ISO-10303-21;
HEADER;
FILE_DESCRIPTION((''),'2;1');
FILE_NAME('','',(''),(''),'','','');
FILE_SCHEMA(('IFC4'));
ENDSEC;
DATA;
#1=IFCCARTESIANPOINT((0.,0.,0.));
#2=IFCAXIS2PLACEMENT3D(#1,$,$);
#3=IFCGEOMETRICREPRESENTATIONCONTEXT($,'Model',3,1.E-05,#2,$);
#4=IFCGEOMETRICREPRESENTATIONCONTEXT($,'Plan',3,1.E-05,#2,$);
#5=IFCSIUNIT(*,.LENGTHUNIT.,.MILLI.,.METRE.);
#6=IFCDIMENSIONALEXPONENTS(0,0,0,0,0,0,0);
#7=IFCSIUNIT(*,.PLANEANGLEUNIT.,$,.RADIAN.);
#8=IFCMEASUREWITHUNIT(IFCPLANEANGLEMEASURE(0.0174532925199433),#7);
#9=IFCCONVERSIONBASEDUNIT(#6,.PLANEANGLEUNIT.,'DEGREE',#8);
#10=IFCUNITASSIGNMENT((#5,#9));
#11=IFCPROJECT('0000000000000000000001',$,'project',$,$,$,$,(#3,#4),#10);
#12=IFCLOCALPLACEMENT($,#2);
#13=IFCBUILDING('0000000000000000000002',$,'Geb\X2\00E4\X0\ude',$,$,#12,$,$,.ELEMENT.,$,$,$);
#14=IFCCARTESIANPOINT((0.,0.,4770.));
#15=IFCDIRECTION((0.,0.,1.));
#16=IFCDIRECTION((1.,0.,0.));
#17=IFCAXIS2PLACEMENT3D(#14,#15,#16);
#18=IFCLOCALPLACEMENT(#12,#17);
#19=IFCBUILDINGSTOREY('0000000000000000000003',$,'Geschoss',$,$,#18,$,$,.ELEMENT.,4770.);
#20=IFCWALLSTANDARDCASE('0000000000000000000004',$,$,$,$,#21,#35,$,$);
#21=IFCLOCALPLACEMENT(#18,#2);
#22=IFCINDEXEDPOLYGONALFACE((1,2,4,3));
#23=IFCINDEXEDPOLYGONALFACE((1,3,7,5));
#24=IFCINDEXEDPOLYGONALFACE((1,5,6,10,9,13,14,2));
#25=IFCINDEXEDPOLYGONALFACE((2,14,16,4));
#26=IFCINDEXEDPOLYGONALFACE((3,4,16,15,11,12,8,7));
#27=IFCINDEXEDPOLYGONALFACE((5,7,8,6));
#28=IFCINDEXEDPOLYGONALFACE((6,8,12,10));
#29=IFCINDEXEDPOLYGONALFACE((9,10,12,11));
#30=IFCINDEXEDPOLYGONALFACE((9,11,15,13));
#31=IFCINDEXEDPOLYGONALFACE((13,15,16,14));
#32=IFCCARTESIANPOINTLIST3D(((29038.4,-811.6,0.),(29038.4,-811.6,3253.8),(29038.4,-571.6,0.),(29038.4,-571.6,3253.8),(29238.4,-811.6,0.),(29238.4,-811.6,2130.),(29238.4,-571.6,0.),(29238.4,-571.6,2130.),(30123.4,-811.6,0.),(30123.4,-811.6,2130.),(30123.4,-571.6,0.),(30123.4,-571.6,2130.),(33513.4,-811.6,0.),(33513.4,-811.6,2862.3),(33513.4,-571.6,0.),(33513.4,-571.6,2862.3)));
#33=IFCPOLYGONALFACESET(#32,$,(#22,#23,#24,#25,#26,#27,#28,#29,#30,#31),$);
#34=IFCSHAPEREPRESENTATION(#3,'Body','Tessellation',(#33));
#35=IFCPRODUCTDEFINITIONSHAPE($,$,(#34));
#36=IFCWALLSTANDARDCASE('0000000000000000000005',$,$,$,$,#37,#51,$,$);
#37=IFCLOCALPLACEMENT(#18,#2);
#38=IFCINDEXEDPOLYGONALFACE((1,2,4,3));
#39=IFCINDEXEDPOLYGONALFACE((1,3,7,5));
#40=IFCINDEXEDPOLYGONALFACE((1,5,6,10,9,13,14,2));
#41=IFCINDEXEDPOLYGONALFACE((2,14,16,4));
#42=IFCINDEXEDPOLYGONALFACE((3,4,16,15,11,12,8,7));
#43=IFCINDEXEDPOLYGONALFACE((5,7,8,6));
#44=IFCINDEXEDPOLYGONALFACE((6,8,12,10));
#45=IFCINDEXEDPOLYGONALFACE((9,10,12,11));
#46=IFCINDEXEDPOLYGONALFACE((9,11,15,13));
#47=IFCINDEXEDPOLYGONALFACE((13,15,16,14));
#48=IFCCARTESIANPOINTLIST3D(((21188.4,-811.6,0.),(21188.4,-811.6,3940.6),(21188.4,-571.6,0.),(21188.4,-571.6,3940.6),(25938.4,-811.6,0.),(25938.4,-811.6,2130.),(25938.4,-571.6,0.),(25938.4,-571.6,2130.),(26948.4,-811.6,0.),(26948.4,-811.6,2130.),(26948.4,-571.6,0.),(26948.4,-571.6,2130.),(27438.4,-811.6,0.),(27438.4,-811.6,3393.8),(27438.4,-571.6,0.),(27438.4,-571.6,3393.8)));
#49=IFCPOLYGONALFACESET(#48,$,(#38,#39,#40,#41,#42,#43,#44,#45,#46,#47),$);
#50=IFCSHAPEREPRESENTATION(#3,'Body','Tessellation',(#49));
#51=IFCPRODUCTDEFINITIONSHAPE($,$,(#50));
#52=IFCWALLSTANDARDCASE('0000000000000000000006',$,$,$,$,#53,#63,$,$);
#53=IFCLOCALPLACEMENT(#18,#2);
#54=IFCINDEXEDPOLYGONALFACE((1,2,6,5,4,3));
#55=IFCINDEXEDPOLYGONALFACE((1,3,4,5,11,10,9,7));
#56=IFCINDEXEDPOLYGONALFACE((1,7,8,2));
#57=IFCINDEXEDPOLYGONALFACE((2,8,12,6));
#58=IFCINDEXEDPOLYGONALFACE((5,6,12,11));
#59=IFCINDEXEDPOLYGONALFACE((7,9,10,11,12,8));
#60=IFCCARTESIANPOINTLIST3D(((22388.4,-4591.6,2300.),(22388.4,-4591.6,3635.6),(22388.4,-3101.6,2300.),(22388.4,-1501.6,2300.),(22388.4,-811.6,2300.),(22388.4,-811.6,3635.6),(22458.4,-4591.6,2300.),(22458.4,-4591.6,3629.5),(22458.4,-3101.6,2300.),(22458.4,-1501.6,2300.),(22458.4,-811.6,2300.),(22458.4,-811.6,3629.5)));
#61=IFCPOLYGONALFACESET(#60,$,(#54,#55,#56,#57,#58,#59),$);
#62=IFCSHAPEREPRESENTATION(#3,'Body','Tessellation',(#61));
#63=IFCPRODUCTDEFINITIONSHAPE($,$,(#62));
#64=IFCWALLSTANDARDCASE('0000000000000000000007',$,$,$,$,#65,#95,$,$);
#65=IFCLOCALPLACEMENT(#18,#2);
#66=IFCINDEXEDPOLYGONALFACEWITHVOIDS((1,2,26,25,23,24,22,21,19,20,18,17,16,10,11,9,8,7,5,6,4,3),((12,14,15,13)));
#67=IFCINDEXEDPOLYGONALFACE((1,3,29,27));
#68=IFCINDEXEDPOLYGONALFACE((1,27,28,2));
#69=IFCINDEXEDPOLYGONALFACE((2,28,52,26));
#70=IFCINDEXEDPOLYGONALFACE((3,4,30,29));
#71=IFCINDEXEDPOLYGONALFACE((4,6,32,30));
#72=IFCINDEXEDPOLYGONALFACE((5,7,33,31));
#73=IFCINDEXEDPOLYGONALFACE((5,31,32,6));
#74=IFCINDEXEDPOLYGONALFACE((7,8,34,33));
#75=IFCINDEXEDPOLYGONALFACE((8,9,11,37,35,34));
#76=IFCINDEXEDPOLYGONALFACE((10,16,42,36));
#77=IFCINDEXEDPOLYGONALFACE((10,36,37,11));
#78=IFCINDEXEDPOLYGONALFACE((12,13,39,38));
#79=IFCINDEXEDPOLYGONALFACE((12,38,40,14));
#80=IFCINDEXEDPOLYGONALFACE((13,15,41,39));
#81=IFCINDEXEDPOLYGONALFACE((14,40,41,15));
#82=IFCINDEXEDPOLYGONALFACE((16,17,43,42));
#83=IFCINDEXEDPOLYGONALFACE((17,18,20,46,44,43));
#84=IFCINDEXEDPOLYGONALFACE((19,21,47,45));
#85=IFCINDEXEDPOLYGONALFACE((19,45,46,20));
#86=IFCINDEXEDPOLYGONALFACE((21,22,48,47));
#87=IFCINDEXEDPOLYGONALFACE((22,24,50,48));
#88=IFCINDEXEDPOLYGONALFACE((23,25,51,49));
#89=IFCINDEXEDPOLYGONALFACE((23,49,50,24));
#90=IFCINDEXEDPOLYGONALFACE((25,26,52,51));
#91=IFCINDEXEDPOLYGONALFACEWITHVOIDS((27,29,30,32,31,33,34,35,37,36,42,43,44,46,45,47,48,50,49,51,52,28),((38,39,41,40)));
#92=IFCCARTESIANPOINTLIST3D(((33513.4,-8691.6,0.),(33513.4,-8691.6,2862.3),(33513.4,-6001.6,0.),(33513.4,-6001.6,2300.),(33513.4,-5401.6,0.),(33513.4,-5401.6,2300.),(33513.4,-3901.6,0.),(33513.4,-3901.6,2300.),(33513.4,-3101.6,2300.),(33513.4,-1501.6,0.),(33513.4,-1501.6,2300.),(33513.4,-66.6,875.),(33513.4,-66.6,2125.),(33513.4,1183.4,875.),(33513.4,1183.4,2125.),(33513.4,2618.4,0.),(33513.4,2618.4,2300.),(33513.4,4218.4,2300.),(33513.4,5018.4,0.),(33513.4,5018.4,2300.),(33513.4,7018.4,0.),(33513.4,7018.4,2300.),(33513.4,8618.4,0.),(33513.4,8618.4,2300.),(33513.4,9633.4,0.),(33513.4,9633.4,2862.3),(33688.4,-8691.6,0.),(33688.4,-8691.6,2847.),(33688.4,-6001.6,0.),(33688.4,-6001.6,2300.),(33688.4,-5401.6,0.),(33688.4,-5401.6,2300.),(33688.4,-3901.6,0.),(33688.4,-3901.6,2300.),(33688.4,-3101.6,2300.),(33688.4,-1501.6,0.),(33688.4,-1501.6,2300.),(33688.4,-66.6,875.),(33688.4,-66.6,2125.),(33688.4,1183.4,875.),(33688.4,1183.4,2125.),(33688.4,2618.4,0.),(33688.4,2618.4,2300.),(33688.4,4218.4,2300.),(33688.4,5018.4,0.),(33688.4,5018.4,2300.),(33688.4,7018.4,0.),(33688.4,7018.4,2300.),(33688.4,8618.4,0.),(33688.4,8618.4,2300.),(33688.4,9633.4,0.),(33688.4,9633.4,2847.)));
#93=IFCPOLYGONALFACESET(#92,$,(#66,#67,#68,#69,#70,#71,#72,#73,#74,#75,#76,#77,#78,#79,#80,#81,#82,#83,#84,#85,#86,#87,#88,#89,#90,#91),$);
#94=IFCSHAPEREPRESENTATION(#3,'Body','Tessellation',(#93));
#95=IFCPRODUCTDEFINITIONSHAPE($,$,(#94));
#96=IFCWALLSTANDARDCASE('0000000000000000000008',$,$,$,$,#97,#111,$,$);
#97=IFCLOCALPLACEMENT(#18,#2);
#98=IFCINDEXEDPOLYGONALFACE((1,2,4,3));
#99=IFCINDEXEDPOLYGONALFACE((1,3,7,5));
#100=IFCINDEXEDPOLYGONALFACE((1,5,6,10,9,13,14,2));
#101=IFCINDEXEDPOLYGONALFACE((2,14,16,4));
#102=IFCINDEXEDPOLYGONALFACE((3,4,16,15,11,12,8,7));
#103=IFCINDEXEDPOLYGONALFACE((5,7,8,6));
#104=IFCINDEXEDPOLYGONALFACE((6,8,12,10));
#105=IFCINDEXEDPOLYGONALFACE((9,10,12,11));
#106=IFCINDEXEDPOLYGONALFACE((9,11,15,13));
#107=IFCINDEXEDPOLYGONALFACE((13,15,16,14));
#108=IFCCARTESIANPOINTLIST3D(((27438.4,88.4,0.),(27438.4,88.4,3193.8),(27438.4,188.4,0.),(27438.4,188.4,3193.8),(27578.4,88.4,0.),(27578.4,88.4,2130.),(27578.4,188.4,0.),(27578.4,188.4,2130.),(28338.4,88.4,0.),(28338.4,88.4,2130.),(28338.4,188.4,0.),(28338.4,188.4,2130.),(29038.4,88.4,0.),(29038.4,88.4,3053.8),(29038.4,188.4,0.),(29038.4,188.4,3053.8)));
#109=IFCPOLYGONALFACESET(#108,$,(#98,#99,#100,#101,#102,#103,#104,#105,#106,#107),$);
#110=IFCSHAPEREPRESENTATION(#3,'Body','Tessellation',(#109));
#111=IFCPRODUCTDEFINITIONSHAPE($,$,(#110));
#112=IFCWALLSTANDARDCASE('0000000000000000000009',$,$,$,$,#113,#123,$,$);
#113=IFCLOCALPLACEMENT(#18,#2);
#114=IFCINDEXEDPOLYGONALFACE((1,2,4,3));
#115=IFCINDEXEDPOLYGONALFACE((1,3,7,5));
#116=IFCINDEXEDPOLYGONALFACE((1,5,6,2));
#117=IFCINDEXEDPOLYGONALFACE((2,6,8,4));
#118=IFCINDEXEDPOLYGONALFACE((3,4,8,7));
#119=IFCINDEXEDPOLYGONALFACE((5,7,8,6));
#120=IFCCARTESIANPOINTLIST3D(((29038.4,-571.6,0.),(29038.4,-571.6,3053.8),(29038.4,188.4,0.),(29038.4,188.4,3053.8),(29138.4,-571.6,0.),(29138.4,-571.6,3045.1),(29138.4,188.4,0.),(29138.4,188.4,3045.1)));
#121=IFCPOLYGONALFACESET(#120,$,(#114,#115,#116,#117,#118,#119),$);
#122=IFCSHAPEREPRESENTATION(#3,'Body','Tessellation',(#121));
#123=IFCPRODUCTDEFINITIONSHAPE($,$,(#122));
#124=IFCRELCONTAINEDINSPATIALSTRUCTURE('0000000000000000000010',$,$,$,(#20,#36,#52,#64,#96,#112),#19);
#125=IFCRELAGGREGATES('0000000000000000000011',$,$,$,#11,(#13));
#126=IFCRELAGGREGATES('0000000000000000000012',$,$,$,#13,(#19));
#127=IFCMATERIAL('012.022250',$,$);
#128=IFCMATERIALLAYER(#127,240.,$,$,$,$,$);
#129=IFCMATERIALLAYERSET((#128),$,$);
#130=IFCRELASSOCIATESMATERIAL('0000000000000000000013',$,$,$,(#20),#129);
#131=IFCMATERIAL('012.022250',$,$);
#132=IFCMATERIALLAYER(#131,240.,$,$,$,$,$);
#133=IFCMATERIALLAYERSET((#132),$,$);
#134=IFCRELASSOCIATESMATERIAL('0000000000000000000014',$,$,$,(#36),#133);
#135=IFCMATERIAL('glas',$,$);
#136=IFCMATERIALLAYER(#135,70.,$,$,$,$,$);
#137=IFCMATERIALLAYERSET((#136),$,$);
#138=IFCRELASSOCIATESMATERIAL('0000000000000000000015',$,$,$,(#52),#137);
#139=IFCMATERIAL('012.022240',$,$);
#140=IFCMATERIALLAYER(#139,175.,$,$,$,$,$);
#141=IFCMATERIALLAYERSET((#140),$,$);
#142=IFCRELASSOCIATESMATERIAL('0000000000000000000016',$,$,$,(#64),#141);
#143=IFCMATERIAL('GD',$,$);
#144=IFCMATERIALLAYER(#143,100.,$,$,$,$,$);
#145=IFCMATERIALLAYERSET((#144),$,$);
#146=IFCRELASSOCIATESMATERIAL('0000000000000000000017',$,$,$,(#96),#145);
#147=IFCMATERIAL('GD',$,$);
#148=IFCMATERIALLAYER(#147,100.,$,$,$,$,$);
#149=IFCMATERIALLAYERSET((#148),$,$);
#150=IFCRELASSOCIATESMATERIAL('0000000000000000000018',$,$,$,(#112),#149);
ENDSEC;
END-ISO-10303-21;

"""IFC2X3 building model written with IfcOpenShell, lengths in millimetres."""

from ifc_helpers import new_model, entity, si_unit, converted_unit, frame, frame_2d, origin, origin_with_axes, place, context, project, spatial, rectangle, extrude, clip, halfspace, material, layer, layer_set, layer_usage, element, save


model = new_model("IFC2X3")

# Units and contexts
model_context = context("Model", 3, precision=1e-05, world=origin())
plan_context = context("Plan", 3, precision=1e-05, world=origin())
ifc_project = project(units=[si_unit("LENGTHUNIT", "METRE", prefix="MILLI"), converted_unit("PLANEANGLEUNIT", "DEGREE", entity("IfcPlaneAngleMeasure", 0.0174532925199433), si_unit("PLANEANGLEUNIT", "RADIAN"), dimensions=[0, 0, 0, 0, 0, 0, 0])], contexts=[model_context, plan_context])

# Building, storey
building_placement = place(None, origin())
building = spatial("IfcBuilding", under=ifc_project, at=building_placement, Name="Gebäude", CompositionType="ELEMENT")
storey_placement = place(building_placement, frame((0.0, 0.0, 4770.0), z_axis=(0.0, 0.0, 1.0), x_axis=(1.0, 0.0, 0.0)))
storey = spatial("IfcBuildingStorey", under=building, at=storey_placement, Name="Geschoss", CompositionType="ELEMENT", Elevation=4770.0)

# Walls, openings
ifc_material_1 = material(Name="012.022250")
ifc_layer_1 = layer(ifc_material_1, 240.0)
ifc_layer_set_1 = layer_set([ifc_layer_1])
ifc_layer_usage_1 = layer_usage(ifc_layer_set_1, "AXIS2", "POSITIVE", 0.0)
wall_1_placement = place(storey_placement, frame((33513.4, -571.6, 0.0), z_axis=(0.0, 0.0, 1.0), x_axis=(-1.0, 0.0, 0.0)))
wall_1 = element("IfcWallStandardCase", 1, at=wall_1_placement, inside=storey, material=ifc_layer_usage_1, context=model_context, shape_type="Clipping", body=[
    clip(extrude(rectangle(XDim=4475.0, YDim=240.0, at=frame_2d((2237.5, 120.0), x_axis=(1.0, 0.0))), origin_with_axes(), (0.0, 0.0, 1.0), 3253.8), halfspace(frame((0.0, 0.0, 2862.3), z_axis=(0.087156, 0.0, -0.996195), x_axis=(1.0, 0.0, 0.0)), True)),
])
opening_1_placement = place(wall_1_placement, frame((3390.0, 0.0, 0.0), z_axis=(0.0, 1.0, 0.0), x_axis=(0.0, 0.0, 1.0)))
element("IfcOpeningElement", 2, at=opening_1_placement, cuts=wall_1, ObjectType="Opening", context=model_context, shape_type="SweptSolid", body=[
    extrude(rectangle(XDim=2130.0, YDim=885.0, at=frame_2d((1065.0, 442.5), x_axis=(1.0, 0.0))), origin_with_axes(), (0.0, 0.0, 1.0), 240.0),
])
ifc_material_2 = material(Name="012.022250")
ifc_layer_2 = layer(ifc_material_2, 240.0)
ifc_layer_set_2 = layer_set([ifc_layer_2])
ifc_layer_usage_2 = layer_usage(ifc_layer_set_2, "AXIS2", "POSITIVE", 0.0)
wall_2_placement = place(storey_placement, frame((27438.4, -571.6, 0.0), z_axis=(0.0, 0.0, 1.0), x_axis=(-1.0, 0.0, 0.0)))
wall_2 = element("IfcWallStandardCase", 3, at=wall_2_placement, inside=storey, material=ifc_layer_usage_2, context=model_context, shape_type="Clipping", body=[
    clip(extrude(rectangle(XDim=6250.0, YDim=240.0, at=frame_2d((3125.0, 120.0), x_axis=(1.0, 0.0))), origin_with_axes(), (0.0, 0.0, 1.0), 3940.6), halfspace(frame((0.0, 0.0, 3393.8), z_axis=(0.087156, 0.0, -0.996195), x_axis=(1.0, 0.0, 0.0)), True)),
])
opening_2_placement = place(wall_2_placement, frame((490.0, 0.0, 0.0), z_axis=(0.0, 1.0, 0.0), x_axis=(0.0, 0.0, 1.0)))
element("IfcOpeningElement", 4, at=opening_2_placement, cuts=wall_2, ObjectType="Opening", context=model_context, shape_type="SweptSolid", body=[
    extrude(rectangle(XDim=2130.0, YDim=1010.0, at=frame_2d((1065.0, 505.0), x_axis=(1.0, 0.0))), origin_with_axes(), (0.0, 0.0, 1.0), 240.0),
])

# Walls, openings
ifc_material_3 = material(Name="glas")
ifc_layer_3 = layer(ifc_material_3, 70.0)
ifc_layer_set_3 = layer_set([ifc_layer_3])
ifc_layer_usage_3 = layer_usage(ifc_layer_set_3, "AXIS2", "POSITIVE", 0.0)
wall_3_placement = place(storey_placement, frame((22458.4, -4591.6, 0.0), z_axis=(0.0, 0.0, 1.0), x_axis=(0.0, 1.0, 0.0)))
wall_3 = element("IfcWallStandardCase", 5, at=wall_3_placement, inside=storey, material=ifc_layer_usage_3, context=model_context, shape_type="Clipping", body=[
    clip(extrude(rectangle(XDim=3780.0, YDim=70.0, at=frame_2d((1890.0, 35.0), x_axis=(1.0, 0.0))), origin_with_axes(), (0.0, 0.0, 1.0), 3635.6), halfspace(frame((0.0, 0.0, 3629.5), z_axis=(0.0, 0.087156, -0.996195), x_axis=(1.0, 0.0, 0.0)), True)),
])
opening_3_placement = place(wall_3_placement, frame((3090.0, 0.0, 0.0), z_axis=(0.0, 1.0, 0.0), x_axis=(0.0, 0.0, 1.0)))
element("IfcOpeningElement", 6, at=opening_3_placement, cuts=wall_3, ObjectType="Opening", context=model_context, shape_type="SweptSolid", body=[
    extrude(rectangle(XDim=2300.0, YDim=690.0, at=frame_2d((1150.0, 345.0), x_axis=(1.0, 0.0))), origin_with_axes(), (0.0, 0.0, 1.0), 70.0),
])
opening_4_placement = place(wall_3_placement, frame((0.0, 0.0, 0.0), z_axis=(0.0, 1.0, 0.0), x_axis=(0.0, 0.0, 1.0)))
element("IfcOpeningElement", 7, at=opening_4_placement, cuts=wall_3, ObjectType="Opening", context=model_context, shape_type="SweptSolid", body=[
    extrude(rectangle(XDim=2300.0, YDim=1490.0, at=frame_2d((1150.0, 745.0), x_axis=(1.0, 0.0))), origin_with_axes(), (0.0, 0.0, 1.0), 70.0),
])
opening_5_placement = place(wall_3_placement, frame((1490.0, 0.0, 0.0), z_axis=(0.0, 1.0, 0.0), x_axis=(0.0, 0.0, 1.0)))
element("IfcOpeningElement", 8, at=opening_5_placement, cuts=wall_3, ObjectType="Opening", context=model_context, shape_type="SweptSolid", body=[
    extrude(rectangle(XDim=2300.0, YDim=1600.0, at=frame_2d((1150.0, 800.0), x_axis=(1.0, 0.0))), origin_with_axes(), (0.0, 0.0, 1.0), 70.0),
])
ifc_material_4 = material(Name="012.022240")
ifc_layer_4 = layer(ifc_material_4, 175.0)
ifc_layer_set_4 = layer_set([ifc_layer_4])
ifc_layer_usage_4 = layer_usage(ifc_layer_set_4, "AXIS2", "POSITIVE", 0.0)
wall_4_placement = place(storey_placement, frame((33688.4, -8691.6, 0.0), z_axis=(0.0, 0.0, 1.0), x_axis=(0.0, 1.0, 0.0)))
wall_4 = element("IfcWallStandardCase", 9, at=wall_4_placement, inside=storey, material=ifc_layer_usage_4, context=model_context, shape_type="Clipping", body=[
    clip(extrude(rectangle(XDim=18325.0, YDim=175.0, at=frame_2d((9162.5, 87.5), x_axis=(1.0, 0.0))), origin_with_axes(), (0.0, 0.0, 1.0), 2862.3), halfspace(frame((18325.0, 175.0, 2862.3), z_axis=(0.0, 0.087156, -0.996195), x_axis=(1.0, 0.0, 0.0)), True)),
])
opening_6_placement = place(wall_4_placement, frame((8625.0, 0.0, 875.0), z_axis=(0.0, 1.0, 0.0), x_axis=(0.0, 0.0, 1.0)))
element("IfcOpeningElement", 10, at=opening_6_placement, cuts=wall_4, ObjectType="Opening", context=model_context, shape_type="SweptSolid", body=[
    extrude(rectangle(XDim=1250.0, YDim=1250.0, at=frame_2d((625.0, 625.0), x_axis=(1.0, 0.0))), origin_with_axes(), (0.0, 0.0, 1.0), 175.0),
])
opening_7_placement = place(wall_4_placement, frame((5590.0, 0.0, 0.0), z_axis=(0.0, 1.0, 0.0), x_axis=(0.0, 0.0, 1.0)))
element("IfcOpeningElement", 11, at=opening_7_placement, cuts=wall_4, ObjectType="Opening", context=model_context, shape_type="SweptSolid", body=[
    extrude(rectangle(XDim=2300.0, YDim=1600.0, at=frame_2d((1150.0, 800.0), x_axis=(1.0, 0.0))), origin_with_axes(), (0.0, 0.0, 1.0), 175.0),
])
opening_8_placement = place(wall_4_placement, frame((2690.0, 0.0, 0.0), z_axis=(0.0, 1.0, 0.0), x_axis=(0.0, 0.0, 1.0)))
element("IfcOpeningElement", 12, at=opening_8_placement, cuts=wall_4, ObjectType="Opening", context=model_context, shape_type="SweptSolid", body=[
    extrude(rectangle(XDim=2300.0, YDim=600.0, at=frame_2d((1150.0, 300.0), x_axis=(1.0, 0.0))), origin_with_axes(), (0.0, 0.0, 1.0), 175.0),
])
opening_9_placement = place(wall_4_placement, frame((11310.0, 0.0, 0.0), z_axis=(0.0, 1.0, 0.0), x_axis=(0.0, 0.0, 1.0)))
element("IfcOpeningElement", 13, at=opening_9_placement, cuts=wall_4, ObjectType="Opening", context=model_context, shape_type="SweptSolid", body=[
    extrude(rectangle(XDim=2300.0, YDim=1600.0, at=frame_2d((1150.0, 800.0), x_axis=(1.0, 0.0))), origin_with_axes(), (0.0, 0.0, 1.0), 175.0),
])
opening_10_placement = place(wall_4_placement, frame((15710.0, 0.0, 0.0), z_axis=(0.0, 1.0, 0.0), x_axis=(0.0, 0.0, 1.0)))
element("IfcOpeningElement", 14, at=opening_10_placement, cuts=wall_4, ObjectType="Opening", context=model_context, shape_type="SweptSolid", body=[
    extrude(rectangle(XDim=2300.0, YDim=1600.0, at=frame_2d((1150.0, 800.0), x_axis=(1.0, 0.0))), origin_with_axes(), (0.0, 0.0, 1.0), 175.0),
])
opening_11_placement = place(wall_4_placement, frame((12910.0, 0.0, 0.0), z_axis=(0.0, 1.0, 0.0), x_axis=(0.0, 0.0, 1.0)))
element("IfcOpeningElement", 15, at=opening_11_placement, cuts=wall_4, ObjectType="Opening", context=model_context, shape_type="SweptSolid", body=[
    extrude(rectangle(XDim=2300.0, YDim=800.0, at=frame_2d((1150.0, 400.0), x_axis=(1.0, 0.0))), origin_with_axes(), (0.0, 0.0, 1.0), 175.0),
])
opening_12_placement = place(wall_4_placement, frame((4790.0, 0.0, 0.0), z_axis=(0.0, 1.0, 0.0), x_axis=(0.0, 0.0, 1.0)))
element("IfcOpeningElement", 16, at=opening_12_placement, cuts=wall_4, ObjectType="Opening", context=model_context, shape_type="SweptSolid", body=[
    extrude(rectangle(XDim=2300.0, YDim=800.0, at=frame_2d((1150.0, 400.0), x_axis=(1.0, 0.0))), origin_with_axes(), (0.0, 0.0, 1.0), 175.0),
])

# Wall, opening
ifc_material_5 = material(Name="GD")
ifc_layer_5 = layer(ifc_material_5, 100.0)
ifc_layer_set_5 = layer_set([ifc_layer_5])
ifc_layer_usage_5 = layer_usage(ifc_layer_set_5, "AXIS2", "POSITIVE", 0.0)
wall_5_placement = place(storey_placement, frame((29038.4, 188.4, 0.0), z_axis=(0.0, 0.0, 1.0), x_axis=(-1.0, 0.0, 0.0)))
wall_5 = element("IfcWallStandardCase", 17, at=wall_5_placement, inside=storey, material=ifc_layer_usage_5, context=model_context, shape_type="Clipping", body=[
    clip(extrude(rectangle(XDim=1600.0, YDim=100.0, at=frame_2d((800.0, 50.0), x_axis=(1.0, 0.0))), origin_with_axes(), (0.0, 0.0, 1.0), 3193.8), halfspace(frame((0.0, 0.0, 3053.8), z_axis=(0.087156, 0.0, -0.996195), x_axis=(1.0, 0.0, 0.0)), True)),
])
opening_13_placement = place(wall_5_placement, frame((700.0, 0.0, 0.0), z_axis=(0.0, 1.0, 0.0), x_axis=(0.0, 0.0, 1.0)))
element("IfcOpeningElement", 18, at=opening_13_placement, cuts=wall_5, ObjectType="Opening", context=model_context, shape_type="SweptSolid", body=[
    extrude(rectangle(XDim=2130.0, YDim=760.0, at=frame_2d((1065.0, 380.0), x_axis=(1.0, 0.0))), origin_with_axes(), (0.0, 0.0, 1.0), 100.0),
])

# Wall
ifc_material_6 = material(Name="GD")
ifc_layer_6 = layer(ifc_material_6, 100.0)
ifc_layer_set_6 = layer_set([ifc_layer_6])
ifc_layer_usage_6 = layer_usage(ifc_layer_set_6, "AXIS2", "POSITIVE", 0.0)
wall_6_placement = place(storey_placement, frame((29138.4, -571.6, 0.0), z_axis=(0.0, 0.0, 1.0), x_axis=(0.0, 1.0, 0.0)))
element("IfcWallStandardCase", 19, at=wall_6_placement, inside=storey, material=ifc_layer_usage_6, context=model_context, shape_type="Clipping", body=[
    clip(extrude(rectangle(XDim=760.0, YDim=100.0, at=frame_2d((380.0, 50.0), x_axis=(1.0, 0.0))), origin_with_axes(), (0.0, 0.0, 1.0), 3053.8), halfspace(frame((0.0, 0.0, 3045.1), z_axis=(0.0, 0.087156, -0.996195), x_axis=(1.0, 0.0, 0.0)), True)),
])

save(model, "model.ifc")
